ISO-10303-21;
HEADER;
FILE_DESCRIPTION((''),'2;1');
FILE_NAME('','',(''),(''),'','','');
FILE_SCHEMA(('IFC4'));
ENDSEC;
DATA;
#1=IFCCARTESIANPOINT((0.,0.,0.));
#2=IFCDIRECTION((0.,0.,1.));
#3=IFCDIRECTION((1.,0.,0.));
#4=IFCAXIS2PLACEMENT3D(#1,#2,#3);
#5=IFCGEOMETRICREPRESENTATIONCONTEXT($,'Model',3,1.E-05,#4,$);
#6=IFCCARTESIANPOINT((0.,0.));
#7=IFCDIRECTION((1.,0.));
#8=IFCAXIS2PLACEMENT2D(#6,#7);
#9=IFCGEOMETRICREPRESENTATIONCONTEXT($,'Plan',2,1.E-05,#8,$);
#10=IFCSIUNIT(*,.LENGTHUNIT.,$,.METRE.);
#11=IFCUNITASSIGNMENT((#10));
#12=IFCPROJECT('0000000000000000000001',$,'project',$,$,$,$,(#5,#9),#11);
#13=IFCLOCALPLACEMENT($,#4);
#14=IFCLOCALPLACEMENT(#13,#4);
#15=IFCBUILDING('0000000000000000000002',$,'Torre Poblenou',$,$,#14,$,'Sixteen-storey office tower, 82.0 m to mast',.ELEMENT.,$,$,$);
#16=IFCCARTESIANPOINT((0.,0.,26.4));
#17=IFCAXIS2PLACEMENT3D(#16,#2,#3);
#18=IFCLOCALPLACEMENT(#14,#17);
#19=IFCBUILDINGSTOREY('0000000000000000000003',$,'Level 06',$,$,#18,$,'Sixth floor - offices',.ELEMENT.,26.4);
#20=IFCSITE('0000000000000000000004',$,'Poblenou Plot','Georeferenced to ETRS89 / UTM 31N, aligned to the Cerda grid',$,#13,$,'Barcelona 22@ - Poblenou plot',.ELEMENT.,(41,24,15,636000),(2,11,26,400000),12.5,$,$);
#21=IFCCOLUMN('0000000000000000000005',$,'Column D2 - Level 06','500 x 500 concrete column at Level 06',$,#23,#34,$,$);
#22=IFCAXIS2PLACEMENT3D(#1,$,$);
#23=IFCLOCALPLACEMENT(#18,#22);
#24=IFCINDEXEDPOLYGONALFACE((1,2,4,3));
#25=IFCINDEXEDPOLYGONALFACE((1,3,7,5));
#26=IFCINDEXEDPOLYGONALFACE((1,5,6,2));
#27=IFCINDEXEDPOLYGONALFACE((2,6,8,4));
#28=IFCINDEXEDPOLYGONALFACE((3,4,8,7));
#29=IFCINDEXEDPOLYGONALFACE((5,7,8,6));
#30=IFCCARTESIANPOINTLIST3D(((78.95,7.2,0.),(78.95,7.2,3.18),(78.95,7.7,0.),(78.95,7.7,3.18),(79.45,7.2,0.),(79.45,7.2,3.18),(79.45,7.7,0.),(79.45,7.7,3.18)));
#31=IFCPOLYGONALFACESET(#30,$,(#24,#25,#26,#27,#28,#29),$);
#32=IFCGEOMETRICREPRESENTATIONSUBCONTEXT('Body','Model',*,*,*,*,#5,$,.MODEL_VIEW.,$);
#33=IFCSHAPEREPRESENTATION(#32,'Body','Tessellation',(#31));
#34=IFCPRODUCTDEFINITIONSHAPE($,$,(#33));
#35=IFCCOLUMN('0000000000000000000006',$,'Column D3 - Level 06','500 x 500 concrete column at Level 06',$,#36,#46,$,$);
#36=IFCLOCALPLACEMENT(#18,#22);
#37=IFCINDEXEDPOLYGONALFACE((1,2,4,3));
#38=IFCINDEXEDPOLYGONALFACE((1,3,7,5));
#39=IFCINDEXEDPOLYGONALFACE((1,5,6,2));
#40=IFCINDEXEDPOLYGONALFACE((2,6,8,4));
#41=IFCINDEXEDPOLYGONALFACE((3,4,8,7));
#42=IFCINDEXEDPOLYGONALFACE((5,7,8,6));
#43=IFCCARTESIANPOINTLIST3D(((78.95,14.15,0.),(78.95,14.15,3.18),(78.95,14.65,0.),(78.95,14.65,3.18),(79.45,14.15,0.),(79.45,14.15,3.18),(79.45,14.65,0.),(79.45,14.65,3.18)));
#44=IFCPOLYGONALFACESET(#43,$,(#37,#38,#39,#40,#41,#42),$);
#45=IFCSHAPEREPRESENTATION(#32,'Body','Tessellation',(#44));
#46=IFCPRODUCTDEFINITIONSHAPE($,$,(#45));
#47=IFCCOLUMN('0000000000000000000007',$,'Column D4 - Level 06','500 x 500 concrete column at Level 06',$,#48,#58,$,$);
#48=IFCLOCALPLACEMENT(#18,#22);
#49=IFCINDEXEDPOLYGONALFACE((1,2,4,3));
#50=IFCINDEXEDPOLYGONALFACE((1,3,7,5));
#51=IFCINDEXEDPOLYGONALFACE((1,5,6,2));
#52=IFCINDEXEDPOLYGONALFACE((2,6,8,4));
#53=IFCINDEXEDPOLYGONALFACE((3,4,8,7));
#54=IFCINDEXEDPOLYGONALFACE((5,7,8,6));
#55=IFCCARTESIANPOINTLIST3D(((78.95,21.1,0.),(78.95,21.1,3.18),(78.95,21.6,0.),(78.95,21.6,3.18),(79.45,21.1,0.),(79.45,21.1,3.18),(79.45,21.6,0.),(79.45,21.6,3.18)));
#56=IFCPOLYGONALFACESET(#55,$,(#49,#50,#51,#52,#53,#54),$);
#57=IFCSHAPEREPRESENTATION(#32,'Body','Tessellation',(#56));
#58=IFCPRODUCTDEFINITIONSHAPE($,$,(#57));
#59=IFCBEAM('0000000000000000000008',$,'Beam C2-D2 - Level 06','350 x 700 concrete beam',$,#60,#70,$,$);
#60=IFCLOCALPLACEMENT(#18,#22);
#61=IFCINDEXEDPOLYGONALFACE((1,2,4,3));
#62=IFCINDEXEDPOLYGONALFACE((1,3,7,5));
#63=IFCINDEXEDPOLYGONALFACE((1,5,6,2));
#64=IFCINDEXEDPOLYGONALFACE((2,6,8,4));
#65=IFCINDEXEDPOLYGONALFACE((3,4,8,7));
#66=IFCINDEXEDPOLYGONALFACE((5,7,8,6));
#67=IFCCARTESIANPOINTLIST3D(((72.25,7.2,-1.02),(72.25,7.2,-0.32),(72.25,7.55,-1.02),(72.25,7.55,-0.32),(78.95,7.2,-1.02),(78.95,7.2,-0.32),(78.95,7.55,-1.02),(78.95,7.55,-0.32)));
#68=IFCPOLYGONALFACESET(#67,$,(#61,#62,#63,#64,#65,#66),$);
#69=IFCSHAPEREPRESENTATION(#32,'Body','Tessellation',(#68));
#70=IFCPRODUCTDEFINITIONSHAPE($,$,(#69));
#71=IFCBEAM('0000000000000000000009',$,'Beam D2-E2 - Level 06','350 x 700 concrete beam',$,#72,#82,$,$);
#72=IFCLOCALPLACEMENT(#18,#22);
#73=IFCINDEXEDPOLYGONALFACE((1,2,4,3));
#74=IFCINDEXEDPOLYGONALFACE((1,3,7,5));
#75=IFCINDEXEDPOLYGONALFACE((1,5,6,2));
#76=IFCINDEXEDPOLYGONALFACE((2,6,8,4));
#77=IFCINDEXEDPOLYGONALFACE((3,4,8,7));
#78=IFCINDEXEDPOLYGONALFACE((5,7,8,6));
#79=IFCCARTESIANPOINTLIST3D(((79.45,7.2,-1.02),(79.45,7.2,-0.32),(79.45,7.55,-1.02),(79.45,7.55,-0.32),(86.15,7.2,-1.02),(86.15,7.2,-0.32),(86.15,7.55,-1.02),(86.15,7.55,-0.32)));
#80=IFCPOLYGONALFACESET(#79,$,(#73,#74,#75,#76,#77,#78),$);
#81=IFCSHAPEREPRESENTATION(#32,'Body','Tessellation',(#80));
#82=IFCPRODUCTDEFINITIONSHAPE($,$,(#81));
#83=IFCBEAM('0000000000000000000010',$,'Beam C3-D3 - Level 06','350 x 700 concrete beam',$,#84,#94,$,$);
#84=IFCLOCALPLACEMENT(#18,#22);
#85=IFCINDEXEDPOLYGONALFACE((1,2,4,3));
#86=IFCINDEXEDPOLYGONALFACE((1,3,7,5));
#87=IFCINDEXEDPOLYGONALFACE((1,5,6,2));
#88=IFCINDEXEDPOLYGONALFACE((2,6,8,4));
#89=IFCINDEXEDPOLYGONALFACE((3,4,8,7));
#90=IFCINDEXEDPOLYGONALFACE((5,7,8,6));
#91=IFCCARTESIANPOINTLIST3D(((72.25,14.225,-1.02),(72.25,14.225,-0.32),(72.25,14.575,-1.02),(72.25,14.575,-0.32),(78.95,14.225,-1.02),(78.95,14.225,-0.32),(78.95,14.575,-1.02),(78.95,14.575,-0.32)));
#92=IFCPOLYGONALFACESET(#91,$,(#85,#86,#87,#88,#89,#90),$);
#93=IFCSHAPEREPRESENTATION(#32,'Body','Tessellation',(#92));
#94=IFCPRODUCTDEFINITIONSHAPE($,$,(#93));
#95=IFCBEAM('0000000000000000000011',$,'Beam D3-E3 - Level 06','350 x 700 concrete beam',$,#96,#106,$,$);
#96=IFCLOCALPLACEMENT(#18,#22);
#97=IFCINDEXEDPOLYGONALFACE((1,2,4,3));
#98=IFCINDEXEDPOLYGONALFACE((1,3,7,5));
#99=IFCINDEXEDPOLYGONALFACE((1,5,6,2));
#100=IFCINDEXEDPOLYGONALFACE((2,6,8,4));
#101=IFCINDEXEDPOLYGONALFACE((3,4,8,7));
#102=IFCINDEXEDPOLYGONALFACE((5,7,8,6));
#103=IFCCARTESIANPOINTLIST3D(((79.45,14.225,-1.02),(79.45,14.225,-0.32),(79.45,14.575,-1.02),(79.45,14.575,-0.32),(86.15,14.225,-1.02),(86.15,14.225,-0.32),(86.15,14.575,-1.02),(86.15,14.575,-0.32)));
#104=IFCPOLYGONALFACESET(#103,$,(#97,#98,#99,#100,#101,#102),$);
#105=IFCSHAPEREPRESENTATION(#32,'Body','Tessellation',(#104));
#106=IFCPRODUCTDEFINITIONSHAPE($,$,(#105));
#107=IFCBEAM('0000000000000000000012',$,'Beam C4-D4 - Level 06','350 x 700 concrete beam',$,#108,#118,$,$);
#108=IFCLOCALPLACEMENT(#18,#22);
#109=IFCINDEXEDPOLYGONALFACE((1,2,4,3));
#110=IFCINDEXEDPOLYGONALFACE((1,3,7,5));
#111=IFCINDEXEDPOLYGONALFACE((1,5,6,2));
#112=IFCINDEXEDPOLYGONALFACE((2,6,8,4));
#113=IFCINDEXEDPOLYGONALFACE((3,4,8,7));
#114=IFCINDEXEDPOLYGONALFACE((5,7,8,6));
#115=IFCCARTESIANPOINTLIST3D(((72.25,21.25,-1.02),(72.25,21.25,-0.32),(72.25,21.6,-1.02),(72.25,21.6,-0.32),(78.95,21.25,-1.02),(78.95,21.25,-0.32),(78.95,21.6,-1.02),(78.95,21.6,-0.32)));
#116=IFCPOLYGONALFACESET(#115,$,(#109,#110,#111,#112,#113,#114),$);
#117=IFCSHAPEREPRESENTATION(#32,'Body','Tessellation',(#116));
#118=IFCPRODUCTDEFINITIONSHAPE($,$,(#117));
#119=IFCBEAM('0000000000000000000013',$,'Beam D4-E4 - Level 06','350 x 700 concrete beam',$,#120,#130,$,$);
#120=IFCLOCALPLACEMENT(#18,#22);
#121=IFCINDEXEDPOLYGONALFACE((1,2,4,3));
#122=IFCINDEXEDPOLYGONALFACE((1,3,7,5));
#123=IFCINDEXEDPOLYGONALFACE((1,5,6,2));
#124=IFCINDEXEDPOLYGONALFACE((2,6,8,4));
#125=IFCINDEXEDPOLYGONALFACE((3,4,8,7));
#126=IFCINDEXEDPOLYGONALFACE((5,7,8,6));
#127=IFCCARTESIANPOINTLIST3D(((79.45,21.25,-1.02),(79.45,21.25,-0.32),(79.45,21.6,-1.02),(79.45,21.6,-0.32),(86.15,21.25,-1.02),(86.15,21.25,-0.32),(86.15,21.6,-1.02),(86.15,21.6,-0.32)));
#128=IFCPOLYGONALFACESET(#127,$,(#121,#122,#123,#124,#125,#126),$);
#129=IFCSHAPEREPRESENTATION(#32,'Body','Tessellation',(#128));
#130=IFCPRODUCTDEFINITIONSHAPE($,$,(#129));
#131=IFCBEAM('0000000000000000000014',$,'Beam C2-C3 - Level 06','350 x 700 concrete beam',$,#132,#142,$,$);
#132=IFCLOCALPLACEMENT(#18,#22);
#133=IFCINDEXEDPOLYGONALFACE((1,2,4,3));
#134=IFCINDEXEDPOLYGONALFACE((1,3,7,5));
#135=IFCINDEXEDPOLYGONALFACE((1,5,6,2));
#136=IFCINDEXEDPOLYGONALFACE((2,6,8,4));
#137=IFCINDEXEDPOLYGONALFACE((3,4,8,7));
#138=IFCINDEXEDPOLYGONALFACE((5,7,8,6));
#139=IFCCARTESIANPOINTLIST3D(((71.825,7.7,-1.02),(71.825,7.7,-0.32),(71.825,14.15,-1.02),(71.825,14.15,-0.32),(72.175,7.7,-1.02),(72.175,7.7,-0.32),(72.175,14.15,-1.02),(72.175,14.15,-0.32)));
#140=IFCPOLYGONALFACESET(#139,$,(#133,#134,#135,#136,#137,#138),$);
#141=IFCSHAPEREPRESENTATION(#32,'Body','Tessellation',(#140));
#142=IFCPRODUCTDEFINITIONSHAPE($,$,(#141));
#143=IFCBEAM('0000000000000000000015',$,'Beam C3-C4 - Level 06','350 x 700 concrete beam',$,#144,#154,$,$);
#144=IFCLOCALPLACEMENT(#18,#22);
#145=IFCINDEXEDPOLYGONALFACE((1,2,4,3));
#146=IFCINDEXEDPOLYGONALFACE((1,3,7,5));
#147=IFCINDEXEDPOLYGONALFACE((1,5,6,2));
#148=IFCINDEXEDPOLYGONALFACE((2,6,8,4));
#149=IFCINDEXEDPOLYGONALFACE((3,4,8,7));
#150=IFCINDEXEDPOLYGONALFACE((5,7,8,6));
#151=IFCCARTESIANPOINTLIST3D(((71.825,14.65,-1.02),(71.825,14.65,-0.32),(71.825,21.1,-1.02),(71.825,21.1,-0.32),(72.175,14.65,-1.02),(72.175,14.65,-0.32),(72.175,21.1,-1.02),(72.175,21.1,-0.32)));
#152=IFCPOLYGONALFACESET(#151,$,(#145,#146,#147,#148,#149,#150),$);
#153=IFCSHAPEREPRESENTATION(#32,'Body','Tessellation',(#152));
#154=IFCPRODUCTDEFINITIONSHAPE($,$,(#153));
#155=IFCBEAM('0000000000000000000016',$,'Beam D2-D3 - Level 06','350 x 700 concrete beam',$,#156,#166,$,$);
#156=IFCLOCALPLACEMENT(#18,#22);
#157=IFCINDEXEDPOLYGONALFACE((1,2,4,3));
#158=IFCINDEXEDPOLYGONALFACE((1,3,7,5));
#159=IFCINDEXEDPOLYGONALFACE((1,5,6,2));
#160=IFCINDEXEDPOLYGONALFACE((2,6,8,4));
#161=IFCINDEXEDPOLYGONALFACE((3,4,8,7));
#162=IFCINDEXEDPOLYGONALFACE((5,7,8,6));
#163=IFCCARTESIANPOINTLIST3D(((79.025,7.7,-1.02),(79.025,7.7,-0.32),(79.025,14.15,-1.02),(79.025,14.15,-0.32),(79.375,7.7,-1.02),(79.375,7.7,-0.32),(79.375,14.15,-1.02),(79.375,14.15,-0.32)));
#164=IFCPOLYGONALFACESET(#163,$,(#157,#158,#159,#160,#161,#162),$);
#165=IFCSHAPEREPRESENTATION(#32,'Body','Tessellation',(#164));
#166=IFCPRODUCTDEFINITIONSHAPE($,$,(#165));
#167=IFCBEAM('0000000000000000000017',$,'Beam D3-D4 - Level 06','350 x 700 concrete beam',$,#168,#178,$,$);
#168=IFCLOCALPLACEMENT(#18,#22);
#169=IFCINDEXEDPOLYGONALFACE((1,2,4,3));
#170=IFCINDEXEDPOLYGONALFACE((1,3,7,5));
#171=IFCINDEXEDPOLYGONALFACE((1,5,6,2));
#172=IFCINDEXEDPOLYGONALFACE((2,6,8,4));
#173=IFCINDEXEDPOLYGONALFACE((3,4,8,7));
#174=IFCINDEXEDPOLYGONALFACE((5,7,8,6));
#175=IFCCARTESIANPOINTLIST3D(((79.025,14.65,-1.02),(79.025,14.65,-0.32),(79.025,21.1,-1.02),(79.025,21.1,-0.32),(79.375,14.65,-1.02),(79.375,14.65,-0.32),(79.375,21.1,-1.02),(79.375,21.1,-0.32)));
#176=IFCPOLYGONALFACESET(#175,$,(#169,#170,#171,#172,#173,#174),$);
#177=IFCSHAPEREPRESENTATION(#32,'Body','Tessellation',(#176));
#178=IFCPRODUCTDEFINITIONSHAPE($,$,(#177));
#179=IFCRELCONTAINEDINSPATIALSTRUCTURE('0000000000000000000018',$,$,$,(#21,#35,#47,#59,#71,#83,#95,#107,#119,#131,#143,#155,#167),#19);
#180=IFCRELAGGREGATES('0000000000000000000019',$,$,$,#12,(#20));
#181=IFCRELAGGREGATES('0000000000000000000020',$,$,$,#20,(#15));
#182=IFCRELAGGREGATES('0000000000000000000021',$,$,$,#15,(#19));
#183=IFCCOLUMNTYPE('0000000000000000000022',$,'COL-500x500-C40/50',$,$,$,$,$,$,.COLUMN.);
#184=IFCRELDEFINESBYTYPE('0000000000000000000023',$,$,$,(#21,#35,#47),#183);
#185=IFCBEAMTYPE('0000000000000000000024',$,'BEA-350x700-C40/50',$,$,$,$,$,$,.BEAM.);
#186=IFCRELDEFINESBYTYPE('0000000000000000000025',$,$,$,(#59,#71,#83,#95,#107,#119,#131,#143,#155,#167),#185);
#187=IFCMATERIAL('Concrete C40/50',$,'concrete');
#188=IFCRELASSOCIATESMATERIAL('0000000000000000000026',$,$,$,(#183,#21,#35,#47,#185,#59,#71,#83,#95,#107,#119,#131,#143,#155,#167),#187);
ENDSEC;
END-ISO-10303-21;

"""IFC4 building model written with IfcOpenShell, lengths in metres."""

from ifc_helpers import new_model, si_unit, frame, origin_with_axes, origin_2d_with_axis, place, context, subcontext, project, spatial, line, indexed_curve, rectangle, outline, extrude, material, material_profile, profile_set, profile_usage, type_object, element, save


model = new_model("IFC4")

# Units and contexts
model_context = context("Model", 3, precision=1e-05, world=origin_with_axes())
plan_context = context("Plan", 2, precision=1e-05, world=origin_2d_with_axis())
body_context = subcontext(model_context, "Body", "Model", "MODEL_VIEW")
ifc_project = project(units=[si_unit("LENGTHUNIT", "METRE")], contexts=[model_context, plan_context])

# Site, building, storey
site_placement = place(None, origin_with_axes())
site = spatial("IfcSite", under=ifc_project, at=site_placement, Name="Poblenou Plot", Description="Georeferenced to ETRS89 / UTM 31N, aligned to the Cerda grid", LongName="Barcelona 22@ - Poblenou plot", CompositionType="ELEMENT", RefLatitude=(41, 24, 15, 636000), RefLongitude=(2, 11, 26, 400000), RefElevation=12.5)
building_placement = place(site_placement, origin_with_axes())
building = spatial("IfcBuilding", under=site, at=building_placement, Name="Torre Poblenou", LongName="Sixteen-storey office tower, 82.0 m to mast", CompositionType="ELEMENT")
storey_placement = place(building_placement, frame((0.0, 0.0, 26.4), z_axis=(0.0, 0.0, 1.0), x_axis=(1.0, 0.0, 0.0)))
storey = spatial("IfcBuildingStorey", under=building, at=storey_placement, Name="Level 06", LongName="Sixth floor - offices", CompositionType="ELEMENT", Elevation=26.4)

# Columns
ifc_material_1 = material(Name="Concrete C40/50", Category="concrete")
ifc_material_profile_1 = material_profile(ifc_material_1, rectangle(XDim=0.5, YDim=0.5))
ifc_profile_set_1 = profile_set([ifc_material_profile_1], Name="COL-500x500-C40/50")
ifc_profile_usage_1 = profile_usage(ifc_profile_set_1)
column_type = type_object("IfcColumnType", Name="COL-500x500-C40/50", PredefinedType="COLUMN", material=ifc_profile_set_1)
column_1_placement = place(storey_placement, frame((78.95, 7.2, 0.0), z_axis=(0.0, 0.0, 1.0), x_axis=(1.0, 0.0, 0.0)))
element("IfcColumn", 1, at=column_1_placement, inside=storey, type_object=column_type, material=ifc_profile_usage_1, Name="Column D2 - Level 06", Description="500 x 500 concrete column at Level 06", context=body_context, shape_type="SweptSolid", body=[
    extrude(outline(indexed_curve([(0.0, 0.0), (0.5, 0.0), (0.5, 0.5), (0.0, 0.5)], segments=[line(1, 2, 3, 4, 1)])), origin_with_axes(), (0.0, 0.0, 1.0), 3.18),
])
ifc_profile_usage_2 = profile_usage(ifc_profile_set_1)
column_2_placement = place(storey_placement, frame((78.95, 14.15, 0.0), z_axis=(0.0, 0.0, 1.0), x_axis=(1.0, 0.0, 0.0)))
element("IfcColumn", 2, at=column_2_placement, inside=storey, type_object=column_type, material=ifc_profile_usage_2, Name="Column D3 - Level 06", Description="500 x 500 concrete column at Level 06", context=body_context, shape_type="SweptSolid", body=[
    extrude(outline(indexed_curve([(0.0, 0.0), (0.5, 0.0), (0.5, 0.5), (0.0, 0.5)], segments=[line(1, 2, 3, 4, 1)])), origin_with_axes(), (0.0, 0.0, 1.0), 3.18),
])
ifc_profile_usage_3 = profile_usage(ifc_profile_set_1)
column_3_placement = place(storey_placement, frame((78.95, 21.1, 0.0), z_axis=(0.0, 0.0, 1.0), x_axis=(1.0, 0.0, 0.0)))
element("IfcColumn", 3, at=column_3_placement, inside=storey, type_object=column_type, material=ifc_profile_usage_3, Name="Column D4 - Level 06", Description="500 x 500 concrete column at Level 06", context=body_context, shape_type="SweptSolid", body=[
    extrude(outline(indexed_curve([(0.0, 0.0), (0.5, 0.0), (0.5, 0.5), (0.0, 0.5)], segments=[line(1, 2, 3, 4, 1)])), origin_with_axes(), (0.0, 0.0, 1.0), 3.18),
])

# Beams
ifc_material_profile_2 = material_profile(ifc_material_1, rectangle(XDim=0.35, YDim=0.7))
ifc_profile_set_2 = profile_set([ifc_material_profile_2], Name="BEA-350x700-C40/50")
ifc_profile_usage_4 = profile_usage(ifc_profile_set_2)
beam_type = type_object("IfcBeamType", Name="BEA-350x700-C40/50", PredefinedType="BEAM", material=ifc_profile_set_2)
beam_1_placement = place(storey_placement, frame((72.25, 7.2, -1.02), z_axis=(0.0, 0.0, 1.0), x_axis=(1.0, 0.0, 0.0)))
element("IfcBeam", 4, at=beam_1_placement, inside=storey, type_object=beam_type, material=ifc_profile_usage_4, Name="Beam C2-D2 - Level 06", Description="350 x 700 concrete beam", context=body_context, shape_type="SweptSolid", body=[
    extrude(outline(indexed_curve([(0.0, 0.0), (6.7, 0.0), (6.7, 0.35), (0.0, 0.35)], segments=[line(1, 2, 3, 4, 1)])), origin_with_axes(), (0.0, 0.0, 1.0), 0.7),
])
ifc_profile_usage_5 = profile_usage(ifc_profile_set_2)
beam_2_placement = place(storey_placement, frame((79.45, 7.2, -1.02), z_axis=(0.0, 0.0, 1.0), x_axis=(1.0, 0.0, 0.0)))
element("IfcBeam", 5, at=beam_2_placement, inside=storey, type_object=beam_type, material=ifc_profile_usage_5, Name="Beam D2-E2 - Level 06", Description="350 x 700 concrete beam", context=body_context, shape_type="SweptSolid", body=[
    extrude(outline(indexed_curve([(0.0, 0.0), (6.7, 0.0), (6.7, 0.35), (0.0, 0.35)], segments=[line(1, 2, 3, 4, 1)])), origin_with_axes(), (0.0, 0.0, 1.0), 0.7),
])
ifc_profile_usage_6 = profile_usage(ifc_profile_set_2)
beam_3_placement = place(storey_placement, frame((72.25, 14.225, -1.02), z_axis=(0.0, 0.0, 1.0), x_axis=(1.0, 0.0, 0.0)))
element("IfcBeam", 6, at=beam_3_placement, inside=storey, type_object=beam_type, material=ifc_profile_usage_6, Name="Beam C3-D3 - Level 06", Description="350 x 700 concrete beam", context=body_context, shape_type="SweptSolid", body=[
    extrude(outline(indexed_curve([(0.0, 0.0), (6.7, 0.0), (6.7, 0.35), (0.0, 0.35)], segments=[line(1, 2, 3, 4, 1)])), origin_with_axes(), (0.0, 0.0, 1.0), 0.7),
])
ifc_profile_usage_7 = profile_usage(ifc_profile_set_2)
beam_4_placement = place(storey_placement, frame((79.45, 14.225, -1.02), z_axis=(0.0, 0.0, 1.0), x_axis=(1.0, 0.0, 0.0)))
element("IfcBeam", 7, at=beam_4_placement, inside=storey, type_object=beam_type, material=ifc_profile_usage_7, Name="Beam D3-E3 - Level 06", Description="350 x 700 concrete beam", context=body_context, shape_type="SweptSolid", body=[
    extrude(outline(indexed_curve([(0.0, 0.0), (6.7, 0.0), (6.7, 0.35), (0.0, 0.35)], segments=[line(1, 2, 3, 4, 1)])), origin_with_axes(), (0.0, 0.0, 1.0), 0.7),
])
ifc_profile_usage_8 = profile_usage(ifc_profile_set_2)
beam_5_placement = place(storey_placement, frame((72.25, 21.25, -1.02), z_axis=(0.0, 0.0, 1.0), x_axis=(1.0, 0.0, 0.0)))
element("IfcBeam", 8, at=beam_5_placement, inside=storey, type_object=beam_type, material=ifc_profile_usage_8, Name="Beam C4-D4 - Level 06", Description="350 x 700 concrete beam", context=body_context, shape_type="SweptSolid", body=[
    extrude(outline(indexed_curve([(0.0, 0.0), (6.7, 0.0), (6.7, 0.35), (0.0, 0.35)], segments=[line(1, 2, 3, 4, 1)])), origin_with_axes(), (0.0, 0.0, 1.0), 0.7),
])
ifc_profile_usage_9 = profile_usage(ifc_profile_set_2)
beam_6_placement = place(storey_placement, frame((79.45, 21.25, -1.02), z_axis=(0.0, 0.0, 1.0), x_axis=(1.0, 0.0, 0.0)))
element("IfcBeam", 9, at=beam_6_placement, inside=storey, type_object=beam_type, material=ifc_profile_usage_9, Name="Beam D4-E4 - Level 06", Description="350 x 700 concrete beam", context=body_context, shape_type="SweptSolid", body=[
    extrude(outline(indexed_curve([(0.0, 0.0), (6.7, 0.0), (6.7, 0.35), (0.0, 0.35)], segments=[line(1, 2, 3, 4, 1)])), origin_with_axes(), (0.0, 0.0, 1.0), 0.7),
])
ifc_profile_usage_10 = profile_usage(ifc_profile_set_2)
beam_7_placement = place(storey_placement, frame((72.175, 7.7, -1.02), z_axis=(0.0, 0.0, 1.0), x_axis=(0.0, 1.0, 0.0)))
element("IfcBeam", 10, at=beam_7_placement, inside=storey, type_object=beam_type, material=ifc_profile_usage_10, Name="Beam C2-C3 - Level 06", Description="350 x 700 concrete beam", context=body_context, shape_type="SweptSolid", body=[
    extrude(outline(indexed_curve([(0.0, 0.0), (6.45, 0.0), (6.45, 0.35), (0.0, 0.35)], segments=[line(1, 2, 3, 4, 1)])), origin_with_axes(), (0.0, 0.0, 1.0), 0.7),
])
ifc_profile_usage_11 = profile_usage(ifc_profile_set_2)
beam_8_placement = place(storey_placement, frame((72.175, 14.65, -1.02), z_axis=(0.0, 0.0, 1.0), x_axis=(0.0, 1.0, 0.0)))
element("IfcBeam", 11, at=beam_8_placement, inside=storey, type_object=beam_type, material=ifc_profile_usage_11, Name="Beam C3-C4 - Level 06", Description="350 x 700 concrete beam", context=body_context, shape_type="SweptSolid", body=[
    extrude(outline(indexed_curve([(0.0, 0.0), (6.45, 0.0), (6.45, 0.35), (0.0, 0.35)], segments=[line(1, 2, 3, 4, 1)])), origin_with_axes(), (0.0, 0.0, 1.0), 0.7),
])
ifc_profile_usage_12 = profile_usage(ifc_profile_set_2)
beam_9_placement = place(storey_placement, frame((79.375, 7.7, -1.02), z_axis=(0.0, 0.0, 1.0), x_axis=(0.0, 1.0, 0.0)))
element("IfcBeam", 12, at=beam_9_placement, inside=storey, type_object=beam_type, material=ifc_profile_usage_12, Name="Beam D2-D3 - Level 06", Description="350 x 700 concrete beam", context=body_context, shape_type="SweptSolid", body=[
    extrude(outline(indexed_curve([(0.0, 0.0), (6.45, 0.0), (6.45, 0.35), (0.0, 0.35)], segments=[line(1, 2, 3, 4, 1)])), origin_with_axes(), (0.0, 0.0, 1.0), 0.7),
])
ifc_profile_usage_13 = profile_usage(ifc_profile_set_2)
beam_10_placement = place(storey_placement, frame((79.375, 14.65, -1.02), z_axis=(0.0, 0.0, 1.0), x_axis=(0.0, 1.0, 0.0)))
element("IfcBeam", 13, at=beam_10_placement, inside=storey, type_object=beam_type, material=ifc_profile_usage_13, Name="Beam D3-D4 - Level 06", Description="350 x 700 concrete beam", context=body_context, shape_type="SweptSolid", body=[
    extrude(outline(indexed_curve([(0.0, 0.0), (6.45, 0.0), (6.45, 0.35), (0.0, 0.35)], segments=[line(1, 2, 3, 4, 1)])), origin_with_axes(), (0.0, 0.0, 1.0), 0.7),
])

save(model, "model.ifc")
